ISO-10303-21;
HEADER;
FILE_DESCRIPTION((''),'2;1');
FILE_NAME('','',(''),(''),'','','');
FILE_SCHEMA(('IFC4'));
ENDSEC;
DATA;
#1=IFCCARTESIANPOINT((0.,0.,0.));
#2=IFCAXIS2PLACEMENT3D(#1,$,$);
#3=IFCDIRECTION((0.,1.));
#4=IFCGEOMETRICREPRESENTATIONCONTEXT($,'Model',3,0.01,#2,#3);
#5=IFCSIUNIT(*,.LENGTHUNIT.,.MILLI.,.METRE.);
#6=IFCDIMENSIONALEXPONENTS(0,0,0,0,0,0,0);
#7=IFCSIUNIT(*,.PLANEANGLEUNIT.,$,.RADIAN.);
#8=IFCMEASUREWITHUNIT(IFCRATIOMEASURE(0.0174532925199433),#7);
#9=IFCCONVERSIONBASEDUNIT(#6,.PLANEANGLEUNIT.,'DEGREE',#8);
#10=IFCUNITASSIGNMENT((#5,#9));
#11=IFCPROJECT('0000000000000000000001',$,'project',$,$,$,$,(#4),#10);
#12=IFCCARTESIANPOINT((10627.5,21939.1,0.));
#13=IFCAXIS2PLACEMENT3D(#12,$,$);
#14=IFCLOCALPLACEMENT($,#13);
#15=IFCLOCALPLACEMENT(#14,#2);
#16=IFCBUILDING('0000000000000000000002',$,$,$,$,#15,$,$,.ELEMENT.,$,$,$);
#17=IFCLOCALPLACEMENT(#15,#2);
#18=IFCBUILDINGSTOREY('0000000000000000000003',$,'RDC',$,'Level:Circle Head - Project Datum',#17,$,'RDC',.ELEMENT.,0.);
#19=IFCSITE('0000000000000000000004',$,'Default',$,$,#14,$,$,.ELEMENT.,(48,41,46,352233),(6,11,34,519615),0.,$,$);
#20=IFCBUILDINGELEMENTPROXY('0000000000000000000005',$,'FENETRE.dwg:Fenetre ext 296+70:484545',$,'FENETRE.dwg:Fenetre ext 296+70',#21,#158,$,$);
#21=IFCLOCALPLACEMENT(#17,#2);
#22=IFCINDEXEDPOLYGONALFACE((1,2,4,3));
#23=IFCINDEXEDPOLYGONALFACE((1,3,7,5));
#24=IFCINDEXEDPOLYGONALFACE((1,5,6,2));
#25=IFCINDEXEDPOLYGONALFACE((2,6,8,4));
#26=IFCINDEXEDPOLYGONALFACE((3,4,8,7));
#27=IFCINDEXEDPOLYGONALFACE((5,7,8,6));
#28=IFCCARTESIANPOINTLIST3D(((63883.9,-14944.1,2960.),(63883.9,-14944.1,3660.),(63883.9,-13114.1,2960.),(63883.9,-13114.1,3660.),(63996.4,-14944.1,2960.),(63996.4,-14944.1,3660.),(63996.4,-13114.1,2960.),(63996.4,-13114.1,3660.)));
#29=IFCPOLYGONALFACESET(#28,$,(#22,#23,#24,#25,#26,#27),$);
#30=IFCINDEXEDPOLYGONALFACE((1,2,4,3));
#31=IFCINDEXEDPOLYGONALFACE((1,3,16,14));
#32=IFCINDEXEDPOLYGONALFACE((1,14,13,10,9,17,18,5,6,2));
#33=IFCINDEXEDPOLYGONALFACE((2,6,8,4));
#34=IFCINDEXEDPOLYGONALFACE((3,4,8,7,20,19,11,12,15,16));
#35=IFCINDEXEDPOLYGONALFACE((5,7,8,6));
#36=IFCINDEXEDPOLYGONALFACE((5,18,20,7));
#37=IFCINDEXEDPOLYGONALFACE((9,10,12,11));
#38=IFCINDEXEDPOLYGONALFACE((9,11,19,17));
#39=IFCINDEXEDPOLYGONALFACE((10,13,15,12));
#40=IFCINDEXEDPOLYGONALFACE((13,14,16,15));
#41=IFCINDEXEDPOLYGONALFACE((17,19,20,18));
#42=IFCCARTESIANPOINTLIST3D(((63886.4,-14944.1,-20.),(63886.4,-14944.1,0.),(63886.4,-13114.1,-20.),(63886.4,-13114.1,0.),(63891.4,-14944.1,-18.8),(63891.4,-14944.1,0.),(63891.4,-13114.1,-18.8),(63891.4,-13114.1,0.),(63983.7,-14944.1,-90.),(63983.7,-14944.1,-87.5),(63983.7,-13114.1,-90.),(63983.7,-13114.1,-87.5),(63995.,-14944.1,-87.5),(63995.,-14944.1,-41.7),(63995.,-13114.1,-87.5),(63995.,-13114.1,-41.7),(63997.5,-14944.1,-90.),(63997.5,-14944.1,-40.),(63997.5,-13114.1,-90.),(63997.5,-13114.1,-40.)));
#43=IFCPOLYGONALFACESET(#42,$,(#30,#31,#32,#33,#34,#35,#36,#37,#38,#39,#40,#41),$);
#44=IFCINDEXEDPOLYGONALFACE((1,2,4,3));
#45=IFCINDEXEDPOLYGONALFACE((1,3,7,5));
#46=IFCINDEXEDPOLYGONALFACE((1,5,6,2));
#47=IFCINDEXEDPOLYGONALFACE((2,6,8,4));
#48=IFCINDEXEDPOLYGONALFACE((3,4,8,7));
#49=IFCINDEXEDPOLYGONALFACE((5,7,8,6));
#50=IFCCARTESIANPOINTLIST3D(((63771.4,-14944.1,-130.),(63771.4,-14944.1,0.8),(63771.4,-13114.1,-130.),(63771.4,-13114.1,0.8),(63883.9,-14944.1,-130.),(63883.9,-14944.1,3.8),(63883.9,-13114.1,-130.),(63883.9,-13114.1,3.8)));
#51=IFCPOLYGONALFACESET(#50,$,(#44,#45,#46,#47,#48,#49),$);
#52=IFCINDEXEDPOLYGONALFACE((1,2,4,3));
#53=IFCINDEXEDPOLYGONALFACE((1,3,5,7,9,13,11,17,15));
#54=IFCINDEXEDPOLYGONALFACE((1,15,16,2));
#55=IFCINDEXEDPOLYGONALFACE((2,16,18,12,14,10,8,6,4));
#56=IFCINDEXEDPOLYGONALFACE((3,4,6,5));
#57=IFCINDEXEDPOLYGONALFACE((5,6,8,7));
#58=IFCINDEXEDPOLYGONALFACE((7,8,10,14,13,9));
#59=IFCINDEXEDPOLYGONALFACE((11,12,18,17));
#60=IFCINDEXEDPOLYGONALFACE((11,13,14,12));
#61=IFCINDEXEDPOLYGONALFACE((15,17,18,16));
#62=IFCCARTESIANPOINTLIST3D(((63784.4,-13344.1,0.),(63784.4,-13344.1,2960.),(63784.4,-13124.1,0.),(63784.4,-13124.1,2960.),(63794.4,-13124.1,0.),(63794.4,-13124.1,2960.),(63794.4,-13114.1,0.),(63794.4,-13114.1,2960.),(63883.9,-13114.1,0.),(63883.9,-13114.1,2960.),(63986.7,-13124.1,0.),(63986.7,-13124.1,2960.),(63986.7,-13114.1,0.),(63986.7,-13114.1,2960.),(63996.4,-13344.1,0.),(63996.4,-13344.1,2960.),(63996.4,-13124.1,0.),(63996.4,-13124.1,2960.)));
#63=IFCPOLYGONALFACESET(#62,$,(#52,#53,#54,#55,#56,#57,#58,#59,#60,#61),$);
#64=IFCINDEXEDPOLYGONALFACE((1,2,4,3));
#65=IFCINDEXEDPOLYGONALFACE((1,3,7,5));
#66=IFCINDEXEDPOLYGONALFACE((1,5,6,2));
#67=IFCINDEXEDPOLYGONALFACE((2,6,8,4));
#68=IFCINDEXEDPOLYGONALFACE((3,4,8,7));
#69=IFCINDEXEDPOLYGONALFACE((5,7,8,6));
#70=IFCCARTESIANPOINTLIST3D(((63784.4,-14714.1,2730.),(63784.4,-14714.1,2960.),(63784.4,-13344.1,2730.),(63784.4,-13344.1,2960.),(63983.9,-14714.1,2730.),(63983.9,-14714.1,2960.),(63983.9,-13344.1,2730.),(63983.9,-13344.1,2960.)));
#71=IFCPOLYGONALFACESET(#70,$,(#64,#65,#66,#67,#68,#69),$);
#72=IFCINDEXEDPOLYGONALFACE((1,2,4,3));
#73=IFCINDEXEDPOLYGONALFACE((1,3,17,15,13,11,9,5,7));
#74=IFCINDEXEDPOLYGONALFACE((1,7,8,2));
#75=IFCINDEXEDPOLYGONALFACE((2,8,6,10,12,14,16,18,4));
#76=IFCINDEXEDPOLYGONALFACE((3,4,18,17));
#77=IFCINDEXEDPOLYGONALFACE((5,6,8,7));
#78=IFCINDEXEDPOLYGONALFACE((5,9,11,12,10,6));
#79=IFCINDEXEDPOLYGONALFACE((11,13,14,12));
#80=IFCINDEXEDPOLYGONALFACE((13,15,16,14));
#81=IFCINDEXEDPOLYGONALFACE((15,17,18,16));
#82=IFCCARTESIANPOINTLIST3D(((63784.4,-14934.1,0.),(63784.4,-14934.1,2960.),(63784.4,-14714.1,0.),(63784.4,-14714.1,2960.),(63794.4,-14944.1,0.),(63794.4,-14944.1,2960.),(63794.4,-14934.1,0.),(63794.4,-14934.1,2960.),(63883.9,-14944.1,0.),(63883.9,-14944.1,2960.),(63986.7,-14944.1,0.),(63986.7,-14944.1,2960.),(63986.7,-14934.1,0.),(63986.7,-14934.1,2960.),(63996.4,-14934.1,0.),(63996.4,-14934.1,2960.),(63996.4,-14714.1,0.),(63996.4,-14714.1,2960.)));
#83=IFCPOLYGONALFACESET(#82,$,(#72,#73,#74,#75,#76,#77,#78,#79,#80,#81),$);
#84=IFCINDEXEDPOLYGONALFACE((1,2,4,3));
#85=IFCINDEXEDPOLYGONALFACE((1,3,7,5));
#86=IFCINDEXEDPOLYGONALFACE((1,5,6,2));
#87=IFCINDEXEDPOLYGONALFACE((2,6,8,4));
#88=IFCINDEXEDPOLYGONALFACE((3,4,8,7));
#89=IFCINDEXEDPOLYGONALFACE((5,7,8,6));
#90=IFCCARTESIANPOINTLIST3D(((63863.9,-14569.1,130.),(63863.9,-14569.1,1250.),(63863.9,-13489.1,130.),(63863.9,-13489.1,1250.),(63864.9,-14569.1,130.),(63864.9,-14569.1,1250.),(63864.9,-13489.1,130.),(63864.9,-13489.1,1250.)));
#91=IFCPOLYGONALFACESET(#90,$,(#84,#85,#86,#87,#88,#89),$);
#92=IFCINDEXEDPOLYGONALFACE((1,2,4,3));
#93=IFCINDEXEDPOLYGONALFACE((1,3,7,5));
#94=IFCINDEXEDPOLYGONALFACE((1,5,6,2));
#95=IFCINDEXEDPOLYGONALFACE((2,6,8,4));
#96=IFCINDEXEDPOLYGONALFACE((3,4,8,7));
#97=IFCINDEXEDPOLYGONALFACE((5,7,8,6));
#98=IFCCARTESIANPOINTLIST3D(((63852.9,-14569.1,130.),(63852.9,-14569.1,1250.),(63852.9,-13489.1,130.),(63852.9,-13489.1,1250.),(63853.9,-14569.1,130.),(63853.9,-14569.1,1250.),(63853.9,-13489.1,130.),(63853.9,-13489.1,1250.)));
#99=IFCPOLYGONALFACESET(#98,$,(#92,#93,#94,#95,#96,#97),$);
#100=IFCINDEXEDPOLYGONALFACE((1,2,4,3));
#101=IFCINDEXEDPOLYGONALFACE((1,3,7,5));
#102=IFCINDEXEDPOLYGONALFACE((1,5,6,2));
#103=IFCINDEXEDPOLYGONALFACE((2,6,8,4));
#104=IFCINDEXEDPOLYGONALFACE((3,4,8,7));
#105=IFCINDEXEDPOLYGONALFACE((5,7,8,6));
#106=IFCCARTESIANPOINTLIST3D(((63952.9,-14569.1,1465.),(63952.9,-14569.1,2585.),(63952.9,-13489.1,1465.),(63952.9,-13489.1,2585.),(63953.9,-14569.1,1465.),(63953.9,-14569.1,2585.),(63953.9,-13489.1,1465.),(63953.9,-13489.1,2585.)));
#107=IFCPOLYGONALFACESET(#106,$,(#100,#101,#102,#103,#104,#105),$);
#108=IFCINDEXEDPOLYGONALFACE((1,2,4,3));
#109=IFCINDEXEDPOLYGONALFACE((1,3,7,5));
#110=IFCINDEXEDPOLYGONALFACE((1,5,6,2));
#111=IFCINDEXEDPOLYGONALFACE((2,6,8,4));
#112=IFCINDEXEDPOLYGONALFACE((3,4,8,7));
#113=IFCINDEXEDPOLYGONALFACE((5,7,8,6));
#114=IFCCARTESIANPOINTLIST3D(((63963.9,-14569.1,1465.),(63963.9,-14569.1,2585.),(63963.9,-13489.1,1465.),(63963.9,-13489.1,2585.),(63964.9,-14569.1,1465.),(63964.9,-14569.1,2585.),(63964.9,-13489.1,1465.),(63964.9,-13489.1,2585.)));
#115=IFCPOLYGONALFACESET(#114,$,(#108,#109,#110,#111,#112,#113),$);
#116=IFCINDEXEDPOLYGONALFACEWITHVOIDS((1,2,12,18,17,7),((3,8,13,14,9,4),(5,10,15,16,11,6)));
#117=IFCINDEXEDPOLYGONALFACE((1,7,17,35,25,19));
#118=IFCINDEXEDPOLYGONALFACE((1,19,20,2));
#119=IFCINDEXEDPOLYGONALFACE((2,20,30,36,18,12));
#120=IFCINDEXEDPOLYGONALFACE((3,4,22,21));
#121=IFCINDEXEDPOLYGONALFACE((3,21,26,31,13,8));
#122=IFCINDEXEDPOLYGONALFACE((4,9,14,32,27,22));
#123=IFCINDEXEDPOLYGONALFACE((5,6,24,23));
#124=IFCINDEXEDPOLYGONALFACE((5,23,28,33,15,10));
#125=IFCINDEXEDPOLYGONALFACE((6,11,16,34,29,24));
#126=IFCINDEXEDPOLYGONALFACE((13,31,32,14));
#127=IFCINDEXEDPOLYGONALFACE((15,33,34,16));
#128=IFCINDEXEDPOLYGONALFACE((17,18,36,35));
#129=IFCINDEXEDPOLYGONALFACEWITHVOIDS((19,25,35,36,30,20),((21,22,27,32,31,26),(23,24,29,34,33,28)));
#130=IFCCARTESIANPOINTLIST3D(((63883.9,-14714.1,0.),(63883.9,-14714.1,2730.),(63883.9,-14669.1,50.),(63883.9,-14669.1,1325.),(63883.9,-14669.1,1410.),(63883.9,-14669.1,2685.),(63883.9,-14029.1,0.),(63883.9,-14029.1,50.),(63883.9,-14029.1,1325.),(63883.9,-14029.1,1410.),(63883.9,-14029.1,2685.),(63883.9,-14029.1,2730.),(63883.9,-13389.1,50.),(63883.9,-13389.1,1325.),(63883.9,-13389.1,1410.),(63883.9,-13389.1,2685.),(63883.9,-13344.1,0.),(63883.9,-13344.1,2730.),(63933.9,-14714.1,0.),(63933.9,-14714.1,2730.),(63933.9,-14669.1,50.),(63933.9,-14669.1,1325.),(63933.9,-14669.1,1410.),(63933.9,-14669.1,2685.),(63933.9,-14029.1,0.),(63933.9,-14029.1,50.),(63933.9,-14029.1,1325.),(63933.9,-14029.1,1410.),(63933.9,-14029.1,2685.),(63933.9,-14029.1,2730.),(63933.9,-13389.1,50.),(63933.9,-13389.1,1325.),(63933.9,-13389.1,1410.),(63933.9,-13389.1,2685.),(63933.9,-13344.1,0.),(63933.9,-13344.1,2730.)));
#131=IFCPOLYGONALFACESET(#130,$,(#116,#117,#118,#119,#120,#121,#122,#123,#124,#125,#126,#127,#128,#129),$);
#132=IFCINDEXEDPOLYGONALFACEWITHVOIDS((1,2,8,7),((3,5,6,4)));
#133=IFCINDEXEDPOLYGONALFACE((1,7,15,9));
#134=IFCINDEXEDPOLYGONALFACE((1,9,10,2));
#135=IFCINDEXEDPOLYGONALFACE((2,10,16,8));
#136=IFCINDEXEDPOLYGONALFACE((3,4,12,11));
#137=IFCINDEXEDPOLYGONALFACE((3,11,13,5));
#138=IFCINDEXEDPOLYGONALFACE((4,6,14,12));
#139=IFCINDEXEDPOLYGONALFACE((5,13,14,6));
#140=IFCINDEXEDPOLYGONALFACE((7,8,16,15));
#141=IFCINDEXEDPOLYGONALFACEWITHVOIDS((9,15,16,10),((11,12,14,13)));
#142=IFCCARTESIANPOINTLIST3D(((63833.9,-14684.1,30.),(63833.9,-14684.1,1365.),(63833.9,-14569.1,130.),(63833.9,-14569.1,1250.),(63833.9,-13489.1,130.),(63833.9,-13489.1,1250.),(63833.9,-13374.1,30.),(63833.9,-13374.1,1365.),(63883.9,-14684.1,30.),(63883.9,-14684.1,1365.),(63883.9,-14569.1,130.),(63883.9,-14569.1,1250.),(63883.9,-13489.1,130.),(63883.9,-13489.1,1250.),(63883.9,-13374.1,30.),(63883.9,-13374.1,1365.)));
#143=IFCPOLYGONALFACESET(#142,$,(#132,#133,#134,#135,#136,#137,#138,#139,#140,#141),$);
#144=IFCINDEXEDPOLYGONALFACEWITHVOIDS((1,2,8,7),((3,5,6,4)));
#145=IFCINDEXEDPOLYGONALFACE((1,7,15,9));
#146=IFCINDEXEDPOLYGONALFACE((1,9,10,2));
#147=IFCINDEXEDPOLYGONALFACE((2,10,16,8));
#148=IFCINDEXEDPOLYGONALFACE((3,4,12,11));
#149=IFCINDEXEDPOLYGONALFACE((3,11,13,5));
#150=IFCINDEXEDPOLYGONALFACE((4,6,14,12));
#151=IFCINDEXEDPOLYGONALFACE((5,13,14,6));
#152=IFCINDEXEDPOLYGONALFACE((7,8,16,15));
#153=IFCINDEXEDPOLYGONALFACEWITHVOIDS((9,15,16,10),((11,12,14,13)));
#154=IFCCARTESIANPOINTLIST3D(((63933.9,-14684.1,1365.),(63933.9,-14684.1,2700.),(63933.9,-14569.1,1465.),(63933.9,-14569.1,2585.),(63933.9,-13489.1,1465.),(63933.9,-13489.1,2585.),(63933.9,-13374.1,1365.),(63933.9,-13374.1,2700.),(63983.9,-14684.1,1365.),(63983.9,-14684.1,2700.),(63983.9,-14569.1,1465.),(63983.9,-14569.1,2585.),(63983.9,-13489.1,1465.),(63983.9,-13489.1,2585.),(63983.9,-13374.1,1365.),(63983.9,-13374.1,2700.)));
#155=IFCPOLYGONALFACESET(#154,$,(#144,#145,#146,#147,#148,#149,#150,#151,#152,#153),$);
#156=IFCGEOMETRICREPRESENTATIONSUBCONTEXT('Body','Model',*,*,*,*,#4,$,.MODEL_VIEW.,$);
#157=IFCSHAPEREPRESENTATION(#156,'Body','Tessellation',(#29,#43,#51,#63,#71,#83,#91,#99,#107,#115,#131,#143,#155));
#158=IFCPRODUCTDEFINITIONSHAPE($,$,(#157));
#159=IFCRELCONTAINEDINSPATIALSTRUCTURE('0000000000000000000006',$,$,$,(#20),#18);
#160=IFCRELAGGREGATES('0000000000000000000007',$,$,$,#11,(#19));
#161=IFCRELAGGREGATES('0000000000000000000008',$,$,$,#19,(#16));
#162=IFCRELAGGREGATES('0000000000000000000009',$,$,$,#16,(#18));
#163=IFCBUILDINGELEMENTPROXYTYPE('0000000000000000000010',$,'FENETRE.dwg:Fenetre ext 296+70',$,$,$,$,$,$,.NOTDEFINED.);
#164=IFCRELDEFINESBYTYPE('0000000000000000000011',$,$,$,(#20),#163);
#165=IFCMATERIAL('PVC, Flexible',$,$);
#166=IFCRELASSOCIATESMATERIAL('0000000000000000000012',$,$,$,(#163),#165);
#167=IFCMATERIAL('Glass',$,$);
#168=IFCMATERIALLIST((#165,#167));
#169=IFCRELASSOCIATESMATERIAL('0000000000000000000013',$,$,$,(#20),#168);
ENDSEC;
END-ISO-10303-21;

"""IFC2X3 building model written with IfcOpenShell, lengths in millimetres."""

from ifc_helpers import new_model, entity, si_unit, converted_unit, direction, frame, frame_2d, origin, origin_2d_with_axis, place, context, subcontext, project, spatial, polyline, rectangle, outline, extrude, source, transform, mapped, material, material_list, type_object, type_shapes, element, save


model = new_model("IFC2X3")

# Units and contexts
model_context = context("Model", 3, precision=0.01, world=origin(), true_north=direction((0.0, 1.0)))
body_context = subcontext(model_context, "Body", "Model", "MODEL_VIEW")
ifc_project = project(units=[si_unit("LENGTHUNIT", "METRE", prefix="MILLI"), converted_unit("PLANEANGLEUNIT", "DEGREE", entity("IfcRatioMeasure", 0.0174532925199433), si_unit("PLANEANGLEUNIT", "RADIAN"), dimensions=[0, 0, 0, 0, 0, 0, 0])], contexts=[model_context])

# Site, building, storey
site_placement = place(None, frame((10627.5, 21939.1, 0.0)))
site = spatial("IfcSite", under=ifc_project, at=site_placement, Name="Default", CompositionType="ELEMENT", RefLatitude=(48, 41, 46, 352233), RefLongitude=(6, 11, 34, 519615), RefElevation=0.0)
building_placement = place(site_placement, origin())
building = spatial("IfcBuilding", under=site, at=building_placement, CompositionType="ELEMENT")
storey_placement = place(building_placement, origin())
storey = spatial("IfcBuildingStorey", under=building, at=storey_placement, Name="RDC", ObjectType="Level:Circle Head - Project Datum", LongName="RDC", CompositionType="ELEMENT", Elevation=0.0)

# Building element proxy
ifc_material_1 = material(Name="PVC, Flexible")
ifc_material_2 = material(Name="Glass")
building_element_proxy_type_1 = type_object("IfcBuildingElementProxyType", Name="FENETRE.dwg:Fenetre ext 296+70", PredefinedType="NOTDEFINED", material=ifc_material_1)
shared_shape_1 = source(origin(), body_context, "Body", "SweptSolid", [
    extrude(rectangle(XDim=112.5, YDim=1830.0, at=origin_2d_with_axis()), frame((-10.4, -56.3, 2960.0), z_axis=(0.0, 0.0, 1.0), x_axis=(0.0, 1.0, 0.0)), (0.0, 0.0, 1.0), 700.0),
    extrude(outline(polyline([(27.5, -64.4), (47.5, -64.4), (47.5, -59.4), (28.8, -59.4), (7.5, 46.7), (-42.5, 46.7), (-42.5, 32.9), (-40.0, 32.9), (-40.0, 44.2), (5.8, 44.2), (27.5, -64.4)])), frame((-925.4, -66.9, -47.5), z_axis=(1.0, 0.0, 0.0), x_axis=(0.0, 0.0, 1.0)), (0.0, 0.0, 1.0), 1830.0),
    extrude(outline(polyline([(-54.5, -66.1), (58.0, -66.1), (54.5, 67.6), (-58.0, 64.6), (-54.5, -66.1)])), frame((-925.4, 56.3, -63.8), z_axis=(1.0, 0.0, 0.0), x_axis=(0.0, -0.999645, 0.02665)), (0.0, 0.0, 1.0), 1830.0),
    extrude(outline(polyline([(-97.0, -55.6), (5.9, -55.6), (95.4, -55.6), (95.4, -45.6), (105.4, -45.6), (105.4, 174.4), (-106.6, 174.4), (-106.6, -45.6), (-97.0, -45.6), (-97.0, -55.6)])), frame((849.0, -5.9, 0.0), z_axis=(0.0, 0.0, 1.0), x_axis=(0.0, 1.0, 0.0)), (0.0, 0.0, 1.0), 2960.0),
    extrude(rectangle(XDim=1370.0, YDim=199.5, at=origin_2d_with_axis()), frame((-10.4, -0.3, 2730.0), z_axis=(0.0, 0.0, 1.0), x_axis=(-1.0, 0.0, 0.0)), (0.0, 0.0, 1.0), 230.0),
    extrude(outline(polyline([(-55.6, 97.0), (-55.6, -5.9), (-55.6, -95.4), (-45.6, -95.4), (-45.6, -105.4), (174.4, -105.4), (174.4, 106.6), (-45.6, 106.6), (-45.6, 97.0), (-55.6, 97.0)])), frame((-869.9, -5.9, 0.0), z_axis=(0.0, 0.0, -1.0), x_axis=(1.0, 0.0, 0.0)), (0.0, 0.0, -1.0), 2960.0),
    extrude(rectangle(XDim=1080.0, YDim=1.0, at=origin_2d_with_axis()), frame((-10.4, 19.5, 130.0), z_axis=(0.0, 0.0, 1.0), x_axis=(-1.0, 0.0, 0.0)), (0.0, 0.0, 1.0), 1120.0),
    extrude(rectangle(XDim=1080.0, YDim=1.0, at=origin_2d_with_axis()), frame((-10.4, 30.5, 130.0), z_axis=(0.0, 0.0, 1.0), x_axis=(-1.0, 0.0, 0.0)), (0.0, 0.0, 1.0), 1120.0),
    extrude(rectangle(XDim=1080.0, YDim=1.0, at=frame_2d((0.0, 0.0), x_axis=(1.0, 0.0))), frame((-10.4, -69.5, 1465.0), z_axis=(0.0, 0.0, 1.0), x_axis=(-1.0, 0.0, 0.0)), (0.0, 0.0, 1.0), 1120.0),
    extrude(rectangle(XDim=1080.0, YDim=1.0, at=frame_2d((0.0, 0.0), x_axis=(1.0, 0.0))), frame((-10.4, -80.5, 1465.0), z_axis=(0.0, 0.0, 1.0), x_axis=(-1.0, 0.0, 0.0)), (0.0, 0.0, 1.0), 1120.0),
    extrude(outline(polyline([(-685.0, -1365.0), (0.0, -1365.0), (685.0, -1365.0), (685.0, 1365.0), (0.0, 1365.0), (-685.0, 1365.0), (-685.0, -1365.0)]), holes=[polyline([(-640.0, -1320.0), (-640.0, -45.0), (0.0, -45.0), (640.0, -45.0), (640.0, -1320.0), (0.0, -1320.0), (-640.0, -1320.0)]), polyline([(-640.0, 40.0), (-640.0, 1315.0), (0.0, 1315.0), (640.0, 1315.0), (640.0, 40.0), (0.0, 40.0), (-640.0, 40.0)])]), frame((-10.4, -50.0, 1365.0), z_axis=(0.0, 1.0, 0.0), x_axis=(1.0, 0.0, 0.0)), (0.0, 0.0, 1.0), 50.0),
    extrude(outline(polyline([(-655.0, -667.5), (655.0, -667.5), (655.0, 667.5), (-655.0, 667.5), (-655.0, -667.5)]), holes=[polyline([(-540.0, 552.5), (540.0, 552.5), (540.0, -567.5), (-540.0, -567.5), (-540.0, 552.5)])]), frame((-10.4, 0.0, 697.5), z_axis=(0.0, 1.0, 0.0), x_axis=(-1.0, 0.0, 0.0)), (0.0, 0.0, 1.0), 50.0),
    extrude(outline(polyline([(-655.0, -667.5), (655.0, -667.5), (655.0, 667.5), (-655.0, 667.5), (-655.0, -667.5)]), holes=[polyline([(-540.0, 552.5), (540.0, 552.5), (540.0, -567.5), (-540.0, -567.5), (-540.0, 552.5)])]), frame((-10.4, -100.0, 2032.5), z_axis=(0.0, 1.0, 0.0), x_axis=(-1.0, 0.0, 0.0)), (0.0, 0.0, 1.0), 50.0),
])
type_shapes(building_element_proxy_type_1, [shared_shape_1])
ifc_material_list_1 = material_list([ifc_material_1, ifc_material_2])
proxy_1_placement = place(storey_placement, frame((63883.9, -14018.7, 0.0), z_axis=(0.0, 0.0, 1.0), x_axis=(0.0, 1.0, 0.0)))
element("IfcBuildingElementProxy", 1, at=proxy_1_placement, inside=storey, type_object=building_element_proxy_type_1, material=ifc_material_list_1, Name="FENETRE.dwg:Fenetre ext 296+70:484545", ObjectType="FENETRE.dwg:Fenetre ext 296+70", context=body_context, shape_type="MappedRepresentation", body=[
    mapped(shared_shape_1, transform((0.0, 0.0, 0.0), scale=1.0)),
])

save(model, "model.ifc")
